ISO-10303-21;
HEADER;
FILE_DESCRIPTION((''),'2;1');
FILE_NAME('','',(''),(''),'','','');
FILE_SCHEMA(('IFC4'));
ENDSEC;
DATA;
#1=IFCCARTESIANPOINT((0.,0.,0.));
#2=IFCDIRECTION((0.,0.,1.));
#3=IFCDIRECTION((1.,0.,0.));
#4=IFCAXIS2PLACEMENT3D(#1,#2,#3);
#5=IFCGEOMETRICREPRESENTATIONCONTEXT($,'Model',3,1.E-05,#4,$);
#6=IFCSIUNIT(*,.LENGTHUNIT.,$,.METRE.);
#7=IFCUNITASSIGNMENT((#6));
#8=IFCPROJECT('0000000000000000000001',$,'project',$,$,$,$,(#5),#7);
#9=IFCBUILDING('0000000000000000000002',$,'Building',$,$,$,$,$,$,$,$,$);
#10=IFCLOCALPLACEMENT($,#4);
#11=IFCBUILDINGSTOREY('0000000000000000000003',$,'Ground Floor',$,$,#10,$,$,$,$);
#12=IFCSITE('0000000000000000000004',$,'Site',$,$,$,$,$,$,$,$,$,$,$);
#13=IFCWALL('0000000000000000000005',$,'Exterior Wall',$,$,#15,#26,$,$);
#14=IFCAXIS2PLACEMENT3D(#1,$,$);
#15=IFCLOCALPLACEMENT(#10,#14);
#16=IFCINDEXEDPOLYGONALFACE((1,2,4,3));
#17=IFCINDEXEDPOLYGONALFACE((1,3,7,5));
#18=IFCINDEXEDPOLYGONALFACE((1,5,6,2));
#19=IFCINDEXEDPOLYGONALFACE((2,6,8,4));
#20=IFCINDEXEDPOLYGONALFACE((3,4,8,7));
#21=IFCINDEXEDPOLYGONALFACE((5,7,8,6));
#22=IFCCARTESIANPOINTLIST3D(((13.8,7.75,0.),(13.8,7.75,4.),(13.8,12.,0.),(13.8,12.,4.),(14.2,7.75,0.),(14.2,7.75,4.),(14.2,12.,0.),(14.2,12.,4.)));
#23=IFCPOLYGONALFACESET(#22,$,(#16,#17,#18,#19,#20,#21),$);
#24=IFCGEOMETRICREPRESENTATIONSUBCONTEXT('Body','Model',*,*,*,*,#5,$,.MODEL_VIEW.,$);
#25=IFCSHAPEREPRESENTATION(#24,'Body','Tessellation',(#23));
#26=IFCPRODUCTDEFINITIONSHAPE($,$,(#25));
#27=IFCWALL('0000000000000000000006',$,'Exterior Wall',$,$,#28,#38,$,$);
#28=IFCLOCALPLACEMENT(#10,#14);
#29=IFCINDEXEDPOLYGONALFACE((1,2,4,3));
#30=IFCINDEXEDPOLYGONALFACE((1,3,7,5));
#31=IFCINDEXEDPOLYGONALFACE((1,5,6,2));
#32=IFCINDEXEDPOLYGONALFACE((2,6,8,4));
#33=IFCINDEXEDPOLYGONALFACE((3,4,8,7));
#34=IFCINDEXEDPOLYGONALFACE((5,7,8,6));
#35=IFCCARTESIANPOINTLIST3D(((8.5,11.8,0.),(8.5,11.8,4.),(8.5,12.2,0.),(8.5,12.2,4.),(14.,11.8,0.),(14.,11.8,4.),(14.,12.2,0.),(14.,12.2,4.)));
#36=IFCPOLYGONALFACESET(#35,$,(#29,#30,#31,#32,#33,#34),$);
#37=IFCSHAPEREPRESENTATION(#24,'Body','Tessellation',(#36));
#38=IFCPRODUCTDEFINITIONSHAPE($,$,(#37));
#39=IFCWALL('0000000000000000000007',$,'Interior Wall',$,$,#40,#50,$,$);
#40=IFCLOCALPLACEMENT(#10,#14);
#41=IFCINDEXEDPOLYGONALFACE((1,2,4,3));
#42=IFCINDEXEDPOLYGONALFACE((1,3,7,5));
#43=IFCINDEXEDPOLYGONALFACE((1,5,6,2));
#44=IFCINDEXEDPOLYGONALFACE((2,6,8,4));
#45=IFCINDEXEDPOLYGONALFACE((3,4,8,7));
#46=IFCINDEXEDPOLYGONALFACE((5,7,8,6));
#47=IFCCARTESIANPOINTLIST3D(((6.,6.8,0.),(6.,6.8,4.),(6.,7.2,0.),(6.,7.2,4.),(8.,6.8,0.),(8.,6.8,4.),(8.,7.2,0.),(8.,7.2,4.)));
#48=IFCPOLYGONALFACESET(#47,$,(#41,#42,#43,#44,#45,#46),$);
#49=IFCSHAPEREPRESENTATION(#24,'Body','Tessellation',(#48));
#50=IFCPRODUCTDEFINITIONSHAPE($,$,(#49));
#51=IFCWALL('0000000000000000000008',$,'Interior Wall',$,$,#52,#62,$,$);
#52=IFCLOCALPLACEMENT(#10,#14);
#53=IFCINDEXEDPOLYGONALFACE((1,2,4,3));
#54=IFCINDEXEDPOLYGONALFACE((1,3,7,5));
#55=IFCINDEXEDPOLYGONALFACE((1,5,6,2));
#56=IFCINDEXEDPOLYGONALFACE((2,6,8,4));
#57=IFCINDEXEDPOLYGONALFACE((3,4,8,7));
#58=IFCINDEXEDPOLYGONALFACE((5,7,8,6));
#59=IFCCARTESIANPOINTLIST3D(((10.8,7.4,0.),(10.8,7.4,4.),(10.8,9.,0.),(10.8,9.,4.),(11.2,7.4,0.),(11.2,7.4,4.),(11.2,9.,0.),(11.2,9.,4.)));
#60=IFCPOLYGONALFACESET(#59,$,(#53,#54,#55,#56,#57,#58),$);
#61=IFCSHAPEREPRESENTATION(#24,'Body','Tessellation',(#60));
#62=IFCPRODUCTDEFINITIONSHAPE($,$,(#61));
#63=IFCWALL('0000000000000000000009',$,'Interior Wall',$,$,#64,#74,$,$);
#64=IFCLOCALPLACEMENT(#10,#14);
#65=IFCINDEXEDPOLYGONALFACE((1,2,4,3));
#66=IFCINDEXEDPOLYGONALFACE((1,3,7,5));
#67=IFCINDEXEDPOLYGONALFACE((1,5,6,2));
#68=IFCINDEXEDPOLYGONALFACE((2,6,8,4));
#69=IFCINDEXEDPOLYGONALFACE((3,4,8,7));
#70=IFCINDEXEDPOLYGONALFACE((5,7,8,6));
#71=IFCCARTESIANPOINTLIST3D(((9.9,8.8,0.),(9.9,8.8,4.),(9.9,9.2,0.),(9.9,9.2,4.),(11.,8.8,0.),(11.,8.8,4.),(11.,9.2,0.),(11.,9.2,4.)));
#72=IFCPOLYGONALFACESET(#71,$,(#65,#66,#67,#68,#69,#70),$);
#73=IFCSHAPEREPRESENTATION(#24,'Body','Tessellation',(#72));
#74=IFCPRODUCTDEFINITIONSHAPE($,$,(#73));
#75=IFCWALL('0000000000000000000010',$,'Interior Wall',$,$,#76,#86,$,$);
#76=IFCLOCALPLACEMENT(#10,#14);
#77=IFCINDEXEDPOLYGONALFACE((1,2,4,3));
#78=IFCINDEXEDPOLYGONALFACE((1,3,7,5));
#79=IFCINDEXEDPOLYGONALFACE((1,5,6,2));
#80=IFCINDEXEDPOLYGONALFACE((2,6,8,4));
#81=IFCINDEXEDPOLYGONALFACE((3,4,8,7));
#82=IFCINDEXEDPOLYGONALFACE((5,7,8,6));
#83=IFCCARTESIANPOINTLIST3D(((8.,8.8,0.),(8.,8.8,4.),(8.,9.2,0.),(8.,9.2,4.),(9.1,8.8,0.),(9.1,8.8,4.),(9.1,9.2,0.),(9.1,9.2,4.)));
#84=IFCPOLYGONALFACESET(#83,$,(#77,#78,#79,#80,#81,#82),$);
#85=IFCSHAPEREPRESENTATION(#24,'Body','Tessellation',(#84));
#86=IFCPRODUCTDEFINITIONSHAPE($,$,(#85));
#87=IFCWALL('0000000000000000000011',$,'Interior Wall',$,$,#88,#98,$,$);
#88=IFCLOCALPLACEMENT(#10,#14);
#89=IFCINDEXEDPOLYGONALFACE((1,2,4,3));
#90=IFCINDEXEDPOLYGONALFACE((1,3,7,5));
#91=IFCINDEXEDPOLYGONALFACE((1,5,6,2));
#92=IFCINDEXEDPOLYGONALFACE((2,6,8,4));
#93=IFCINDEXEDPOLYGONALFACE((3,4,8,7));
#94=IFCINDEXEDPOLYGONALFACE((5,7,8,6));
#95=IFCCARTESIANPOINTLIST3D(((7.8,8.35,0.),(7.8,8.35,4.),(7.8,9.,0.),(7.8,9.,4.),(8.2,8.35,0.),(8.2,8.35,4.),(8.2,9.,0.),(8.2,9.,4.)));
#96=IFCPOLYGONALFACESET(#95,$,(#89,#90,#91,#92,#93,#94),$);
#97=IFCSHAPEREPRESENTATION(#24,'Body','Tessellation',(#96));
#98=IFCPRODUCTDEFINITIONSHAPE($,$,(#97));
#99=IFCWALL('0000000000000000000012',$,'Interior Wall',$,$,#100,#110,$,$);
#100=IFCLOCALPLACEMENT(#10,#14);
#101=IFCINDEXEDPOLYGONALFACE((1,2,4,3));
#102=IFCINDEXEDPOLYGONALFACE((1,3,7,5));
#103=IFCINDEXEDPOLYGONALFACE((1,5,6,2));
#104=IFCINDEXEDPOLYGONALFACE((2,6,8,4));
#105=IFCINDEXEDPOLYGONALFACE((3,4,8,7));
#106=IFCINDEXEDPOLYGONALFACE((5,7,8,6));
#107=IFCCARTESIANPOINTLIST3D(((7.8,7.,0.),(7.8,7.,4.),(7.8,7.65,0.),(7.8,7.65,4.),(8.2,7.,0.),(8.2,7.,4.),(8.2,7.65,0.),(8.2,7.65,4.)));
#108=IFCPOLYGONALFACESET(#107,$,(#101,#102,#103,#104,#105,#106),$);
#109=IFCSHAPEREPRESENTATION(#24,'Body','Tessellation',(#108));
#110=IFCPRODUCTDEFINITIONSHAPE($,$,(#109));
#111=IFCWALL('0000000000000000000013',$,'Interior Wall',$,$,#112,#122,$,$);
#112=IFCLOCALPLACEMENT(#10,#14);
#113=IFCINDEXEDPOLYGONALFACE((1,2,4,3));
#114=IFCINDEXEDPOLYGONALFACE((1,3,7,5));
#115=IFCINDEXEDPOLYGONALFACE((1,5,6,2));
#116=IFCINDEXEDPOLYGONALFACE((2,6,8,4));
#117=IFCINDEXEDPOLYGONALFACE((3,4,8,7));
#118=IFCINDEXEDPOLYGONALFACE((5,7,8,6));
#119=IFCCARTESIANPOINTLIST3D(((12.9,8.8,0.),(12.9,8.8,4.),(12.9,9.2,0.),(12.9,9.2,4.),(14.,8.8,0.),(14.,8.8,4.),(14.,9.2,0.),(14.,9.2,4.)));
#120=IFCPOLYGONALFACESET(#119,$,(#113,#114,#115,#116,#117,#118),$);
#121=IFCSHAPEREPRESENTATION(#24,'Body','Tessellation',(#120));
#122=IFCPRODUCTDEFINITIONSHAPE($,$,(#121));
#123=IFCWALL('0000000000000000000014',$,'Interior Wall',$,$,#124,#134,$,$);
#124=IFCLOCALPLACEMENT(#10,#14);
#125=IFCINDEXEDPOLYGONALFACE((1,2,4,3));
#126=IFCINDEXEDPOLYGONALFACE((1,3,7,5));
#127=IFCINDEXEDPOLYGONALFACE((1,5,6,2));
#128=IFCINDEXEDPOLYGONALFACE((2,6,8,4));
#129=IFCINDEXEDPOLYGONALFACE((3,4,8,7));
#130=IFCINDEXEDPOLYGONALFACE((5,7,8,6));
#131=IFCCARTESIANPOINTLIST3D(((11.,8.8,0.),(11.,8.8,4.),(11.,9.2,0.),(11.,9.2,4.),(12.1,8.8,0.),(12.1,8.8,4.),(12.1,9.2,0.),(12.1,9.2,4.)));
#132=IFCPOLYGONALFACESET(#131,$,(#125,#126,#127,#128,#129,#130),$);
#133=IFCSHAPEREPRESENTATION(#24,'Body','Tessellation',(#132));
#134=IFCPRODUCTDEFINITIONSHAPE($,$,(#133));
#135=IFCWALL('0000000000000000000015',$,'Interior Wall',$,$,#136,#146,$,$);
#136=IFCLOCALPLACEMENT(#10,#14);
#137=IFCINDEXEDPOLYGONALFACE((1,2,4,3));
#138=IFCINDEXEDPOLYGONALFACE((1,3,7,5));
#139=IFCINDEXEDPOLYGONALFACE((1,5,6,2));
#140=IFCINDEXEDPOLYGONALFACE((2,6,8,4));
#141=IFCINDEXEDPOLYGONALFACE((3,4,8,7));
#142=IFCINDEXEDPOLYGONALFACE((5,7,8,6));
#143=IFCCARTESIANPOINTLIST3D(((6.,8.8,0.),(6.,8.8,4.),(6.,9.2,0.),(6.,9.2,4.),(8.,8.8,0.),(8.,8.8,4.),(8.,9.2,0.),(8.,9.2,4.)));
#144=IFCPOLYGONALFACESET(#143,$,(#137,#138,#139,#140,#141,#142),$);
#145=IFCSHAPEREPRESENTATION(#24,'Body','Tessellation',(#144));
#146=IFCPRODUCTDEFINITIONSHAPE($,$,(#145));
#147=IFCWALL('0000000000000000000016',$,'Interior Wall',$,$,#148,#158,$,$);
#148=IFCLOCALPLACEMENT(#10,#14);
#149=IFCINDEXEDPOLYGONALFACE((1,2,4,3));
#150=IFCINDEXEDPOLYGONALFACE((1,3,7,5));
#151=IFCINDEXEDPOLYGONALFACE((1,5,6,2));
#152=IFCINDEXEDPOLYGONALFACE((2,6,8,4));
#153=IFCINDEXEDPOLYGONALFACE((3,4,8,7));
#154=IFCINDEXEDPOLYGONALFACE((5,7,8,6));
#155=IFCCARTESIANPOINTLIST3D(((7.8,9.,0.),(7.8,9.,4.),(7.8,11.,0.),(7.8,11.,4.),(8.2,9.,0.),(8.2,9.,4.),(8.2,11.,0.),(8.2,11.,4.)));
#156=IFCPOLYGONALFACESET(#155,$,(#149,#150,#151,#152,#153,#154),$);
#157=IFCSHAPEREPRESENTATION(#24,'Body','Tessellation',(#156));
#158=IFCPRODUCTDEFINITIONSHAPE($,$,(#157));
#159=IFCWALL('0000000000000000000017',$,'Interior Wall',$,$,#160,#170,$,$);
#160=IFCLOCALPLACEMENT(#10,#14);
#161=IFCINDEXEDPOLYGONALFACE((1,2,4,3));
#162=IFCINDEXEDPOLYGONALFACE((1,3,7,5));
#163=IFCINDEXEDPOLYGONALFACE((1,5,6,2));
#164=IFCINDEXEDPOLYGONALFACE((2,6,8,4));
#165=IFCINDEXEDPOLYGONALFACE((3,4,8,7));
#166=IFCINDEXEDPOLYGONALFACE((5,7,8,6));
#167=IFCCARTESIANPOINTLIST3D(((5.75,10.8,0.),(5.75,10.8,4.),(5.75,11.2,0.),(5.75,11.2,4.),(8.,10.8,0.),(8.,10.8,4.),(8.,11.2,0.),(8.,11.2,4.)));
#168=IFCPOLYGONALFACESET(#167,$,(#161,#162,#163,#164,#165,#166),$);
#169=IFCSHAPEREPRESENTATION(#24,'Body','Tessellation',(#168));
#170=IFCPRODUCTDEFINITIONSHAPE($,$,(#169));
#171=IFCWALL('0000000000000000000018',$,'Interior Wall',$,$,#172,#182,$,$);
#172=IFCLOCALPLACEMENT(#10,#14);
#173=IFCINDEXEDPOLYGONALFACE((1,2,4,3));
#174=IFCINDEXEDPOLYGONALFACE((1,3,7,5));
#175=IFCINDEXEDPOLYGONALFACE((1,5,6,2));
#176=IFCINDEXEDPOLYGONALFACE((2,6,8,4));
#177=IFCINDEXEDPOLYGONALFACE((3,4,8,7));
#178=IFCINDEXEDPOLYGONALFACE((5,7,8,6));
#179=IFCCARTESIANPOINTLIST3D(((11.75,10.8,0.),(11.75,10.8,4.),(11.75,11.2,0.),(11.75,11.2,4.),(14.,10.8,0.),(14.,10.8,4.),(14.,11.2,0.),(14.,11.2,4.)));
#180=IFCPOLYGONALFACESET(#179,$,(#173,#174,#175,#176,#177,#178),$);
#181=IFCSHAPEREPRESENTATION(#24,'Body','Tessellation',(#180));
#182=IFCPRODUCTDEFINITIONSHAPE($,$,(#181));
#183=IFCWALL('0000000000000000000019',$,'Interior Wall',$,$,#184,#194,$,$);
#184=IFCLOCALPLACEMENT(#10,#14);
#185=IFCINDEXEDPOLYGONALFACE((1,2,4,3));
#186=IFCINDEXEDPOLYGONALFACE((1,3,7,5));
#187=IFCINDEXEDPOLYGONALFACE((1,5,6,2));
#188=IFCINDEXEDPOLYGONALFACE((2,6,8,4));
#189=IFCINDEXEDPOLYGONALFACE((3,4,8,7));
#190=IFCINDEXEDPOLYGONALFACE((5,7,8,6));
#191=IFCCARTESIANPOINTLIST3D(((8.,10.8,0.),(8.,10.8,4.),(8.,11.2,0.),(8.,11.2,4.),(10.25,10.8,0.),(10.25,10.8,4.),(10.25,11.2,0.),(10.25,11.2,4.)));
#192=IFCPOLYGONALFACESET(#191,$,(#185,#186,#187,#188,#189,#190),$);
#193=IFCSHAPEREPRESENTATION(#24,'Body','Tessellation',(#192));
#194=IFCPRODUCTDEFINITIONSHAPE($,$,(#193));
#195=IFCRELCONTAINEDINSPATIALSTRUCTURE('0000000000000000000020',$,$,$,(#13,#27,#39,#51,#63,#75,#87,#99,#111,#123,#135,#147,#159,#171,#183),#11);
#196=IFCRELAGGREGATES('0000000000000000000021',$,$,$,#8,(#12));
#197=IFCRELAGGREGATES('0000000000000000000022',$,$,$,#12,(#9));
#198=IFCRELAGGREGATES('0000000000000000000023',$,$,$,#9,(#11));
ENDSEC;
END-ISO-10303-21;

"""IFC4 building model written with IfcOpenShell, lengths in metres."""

from ifc_helpers import new_model, si_unit, frame, origin_with_axes, place, context, subcontext, project, spatial, indexed_curve, outline, extrude, element, save


model = new_model("IFC4")

# Units and contexts
model_context = context("Model", 3, precision=1e-05, world=origin_with_axes())
body_context = subcontext(model_context, "Body", "Model", "MODEL_VIEW")
ifc_project = project(units=[si_unit("LENGTHUNIT", "METRE")], contexts=[model_context])

# Site, building, storey
site = spatial("IfcSite", under=ifc_project, Name="Site")
building = spatial("IfcBuilding", under=site, Name="Building")
storey_placement = place(None, origin_with_axes())
storey = spatial("IfcBuildingStorey", under=building, at=storey_placement, Name="Ground Floor")

# Walls
wall_1_placement = place(storey_placement, frame((14.0, 7.75, 0.0), z_axis=(0.0, 0.0, 1.0), x_axis=(0.0, 1.0, 0.0)))
element("IfcWall", 1, at=wall_1_placement, inside=storey, Name="Exterior Wall", context=body_context, shape_type="SweptSolid", body=[
    extrude(outline(indexed_curve([(0.0, 0.0), (0.0, 0.4), (4.25, 0.4), (4.25, 0.0), (0.0, 0.0)], self_intersect=False)), frame((0.0, -0.2, 0.0), z_axis=(0.0, 0.0, 1.0), x_axis=(1.0, 0.0, 0.0)), (0.0, 0.0, 1.0), 4.0),
])
wall_2_placement = place(storey_placement, frame((14.0, 12.0, 0.0), z_axis=(0.0, 0.0, 1.0), x_axis=(-1.0, 0.0, 0.0)))
element("IfcWall", 2, at=wall_2_placement, inside=storey, Name="Exterior Wall", context=body_context, shape_type="SweptSolid", body=[
    extrude(outline(indexed_curve([(0.0, 0.0), (0.0, 0.4), (5.5, 0.4), (5.5, 0.0), (0.0, 0.0)], self_intersect=False)), frame((0.0, -0.2, 0.0), z_axis=(0.0, 0.0, 1.0), x_axis=(1.0, 0.0, 0.0)), (0.0, 0.0, 1.0), 4.0),
])
wall_3_placement = place(storey_placement, frame((8.0, 7.0, 0.0), z_axis=(0.0, 0.0, 1.0), x_axis=(-1.0, 0.0, 0.0)))
element("IfcWall", 3, at=wall_3_placement, inside=storey, Name="Interior Wall", context=body_context, shape_type="SweptSolid", body=[
    extrude(outline(indexed_curve([(0.0, 0.0), (0.0, 0.4), (2.0, 0.4), (2.0, 0.0), (0.0, 0.0)], self_intersect=False)), frame((0.0, -0.2, 0.0), z_axis=(0.0, 0.0, 1.0), x_axis=(1.0, 0.0, 0.0)), (0.0, 0.0, 1.0), 4.0),
])
wall_4_placement = place(storey_placement, frame((11.0, 7.4, 0.0), z_axis=(0.0, 0.0, 1.0), x_axis=(0.0, 1.0, 0.0)))
element("IfcWall", 4, at=wall_4_placement, inside=storey, Name="Interior Wall", context=body_context, shape_type="SweptSolid", body=[
    extrude(outline(indexed_curve([(0.0, 0.0), (0.0, 0.4), (1.6, 0.4), (1.6, 0.0), (0.0, 0.0)], self_intersect=False)), frame((0.0, -0.2, 0.0), z_axis=(0.0, 0.0, 1.0), x_axis=(1.0, 0.0, 0.0)), (0.0, 0.0, 1.0), 4.0),
])
for number, where, z_axis, x_axis, name in (
    (5, (11.0, 9.0, 0.0), (0.0, 0.0, 1.0), (-1.0, 0.0, 0.0), "Interior Wall"),
    (6, (9.1, 9.0, 0.0), (0.0, 0.0, 1.0), (-1.0, 0.0, 0.0), "Interior Wall"),
):
    element("IfcWall", number, at=place(storey_placement, frame(where, z_axis=z_axis, x_axis=x_axis)), inside=storey, Name=name, context=body_context, shape_type="SweptSolid", body=[
        extrude(outline(indexed_curve([(0.0, 0.0), (0.0, 0.4), (1.1, 0.4), (1.1, 0.0), (0.0, 0.0)], self_intersect=False)), frame((0.0, -0.2, 0.0), z_axis=(0.0, 0.0, 1.0), x_axis=(1.0, 0.0, 0.0)), (0.0, 0.0, 1.0), 4.0),
    ])
for number, where, z_axis, x_axis, name in (
    (7, (8.0, 9.0, 0.0), (0.0, 0.0, 1.0), (0.0, -1.0, 0.0), "Interior Wall"),
    (8, (8.0, 7.65, 0.0), (0.0, 0.0, 1.0), (0.0, -1.0, 0.0), "Interior Wall"),
):
    element("IfcWall", number, at=place(storey_placement, frame(where, z_axis=z_axis, x_axis=x_axis)), inside=storey, Name=name, context=body_context, shape_type="SweptSolid", body=[
        extrude(outline(indexed_curve([(0.0, 0.0), (0.0, 0.4), (0.65, 0.4), (0.65, 0.0), (0.0, 0.0)], self_intersect=False)), frame((0.0, -0.2, 0.0), z_axis=(0.0, 0.0, 1.0), x_axis=(1.0, 0.0, 0.0)), (0.0, 0.0, 1.0), 4.0),
    ])
for number, where, z_axis, x_axis, name in (
    (9, (14.0, 9.0, 0.0), (0.0, 0.0, 1.0), (-1.0, 0.0, 0.0), "Interior Wall"),
    (10, (12.1, 9.0, 0.0), (0.0, 0.0, 1.0), (-1.0, 0.0, 0.0), "Interior Wall"),
):
    element("IfcWall", number, at=place(storey_placement, frame(where, z_axis=z_axis, x_axis=x_axis)), inside=storey, Name=name, context=body_context, shape_type="SweptSolid", body=[
        extrude(outline(indexed_curve([(0.0, 0.0), (0.0, 0.4), (1.1, 0.4), (1.1, 0.0), (0.0, 0.0)], self_intersect=False)), frame((0.0, -0.2, 0.0), z_axis=(0.0, 0.0, 1.0), x_axis=(1.0, 0.0, 0.0)), (0.0, 0.0, 1.0), 4.0),
    ])
for number, where, z_axis, x_axis, name in (
    (11, (8.0, 9.0, 0.0), (0.0, 0.0, 1.0), (-1.0, 0.0, 0.0), "Interior Wall"),
    (12, (8.0, 9.0, 0.0), (0.0, 0.0, 1.0), (0.0, 1.0, 0.0), "Interior Wall"),
):
    element("IfcWall", number, at=place(storey_placement, frame(where, z_axis=z_axis, x_axis=x_axis)), inside=storey, Name=name, context=body_context, shape_type="SweptSolid", body=[
        extrude(outline(indexed_curve([(0.0, 0.0), (0.0, 0.4), (2.0, 0.4), (2.0, 0.0), (0.0, 0.0)], self_intersect=False)), frame((0.0, -0.2, 0.0), z_axis=(0.0, 0.0, 1.0), x_axis=(1.0, 0.0, 0.0)), (0.0, 0.0, 1.0), 4.0),
    ])
for number, where, z_axis, x_axis, name in (
    (13, (8.0, 11.0, 0.0), (0.0, 0.0, 1.0), (-1.0, 0.0, 0.0), "Interior Wall"),
    (14, (14.0, 11.0, 0.0), (0.0, 0.0, 1.0), (-1.0, 0.0, 0.0), "Interior Wall"),
    (15, (10.25, 11.0, 0.0), (0.0, 0.0, 1.0), (-1.0, 0.0, 0.0), "Interior Wall"),
):
    element("IfcWall", number, at=place(storey_placement, frame(where, z_axis=z_axis, x_axis=x_axis)), inside=storey, Name=name, context=body_context, shape_type="SweptSolid", body=[
        extrude(outline(indexed_curve([(0.0, 0.0), (0.0, 0.4), (2.25, 0.4), (2.25, 0.0), (0.0, 0.0)], self_intersect=False)), frame((0.0, -0.2, 0.0), z_axis=(0.0, 0.0, 1.0), x_axis=(1.0, 0.0, 0.0)), (0.0, 0.0, 1.0), 4.0),
    ])

save(model, "model.ifc")
